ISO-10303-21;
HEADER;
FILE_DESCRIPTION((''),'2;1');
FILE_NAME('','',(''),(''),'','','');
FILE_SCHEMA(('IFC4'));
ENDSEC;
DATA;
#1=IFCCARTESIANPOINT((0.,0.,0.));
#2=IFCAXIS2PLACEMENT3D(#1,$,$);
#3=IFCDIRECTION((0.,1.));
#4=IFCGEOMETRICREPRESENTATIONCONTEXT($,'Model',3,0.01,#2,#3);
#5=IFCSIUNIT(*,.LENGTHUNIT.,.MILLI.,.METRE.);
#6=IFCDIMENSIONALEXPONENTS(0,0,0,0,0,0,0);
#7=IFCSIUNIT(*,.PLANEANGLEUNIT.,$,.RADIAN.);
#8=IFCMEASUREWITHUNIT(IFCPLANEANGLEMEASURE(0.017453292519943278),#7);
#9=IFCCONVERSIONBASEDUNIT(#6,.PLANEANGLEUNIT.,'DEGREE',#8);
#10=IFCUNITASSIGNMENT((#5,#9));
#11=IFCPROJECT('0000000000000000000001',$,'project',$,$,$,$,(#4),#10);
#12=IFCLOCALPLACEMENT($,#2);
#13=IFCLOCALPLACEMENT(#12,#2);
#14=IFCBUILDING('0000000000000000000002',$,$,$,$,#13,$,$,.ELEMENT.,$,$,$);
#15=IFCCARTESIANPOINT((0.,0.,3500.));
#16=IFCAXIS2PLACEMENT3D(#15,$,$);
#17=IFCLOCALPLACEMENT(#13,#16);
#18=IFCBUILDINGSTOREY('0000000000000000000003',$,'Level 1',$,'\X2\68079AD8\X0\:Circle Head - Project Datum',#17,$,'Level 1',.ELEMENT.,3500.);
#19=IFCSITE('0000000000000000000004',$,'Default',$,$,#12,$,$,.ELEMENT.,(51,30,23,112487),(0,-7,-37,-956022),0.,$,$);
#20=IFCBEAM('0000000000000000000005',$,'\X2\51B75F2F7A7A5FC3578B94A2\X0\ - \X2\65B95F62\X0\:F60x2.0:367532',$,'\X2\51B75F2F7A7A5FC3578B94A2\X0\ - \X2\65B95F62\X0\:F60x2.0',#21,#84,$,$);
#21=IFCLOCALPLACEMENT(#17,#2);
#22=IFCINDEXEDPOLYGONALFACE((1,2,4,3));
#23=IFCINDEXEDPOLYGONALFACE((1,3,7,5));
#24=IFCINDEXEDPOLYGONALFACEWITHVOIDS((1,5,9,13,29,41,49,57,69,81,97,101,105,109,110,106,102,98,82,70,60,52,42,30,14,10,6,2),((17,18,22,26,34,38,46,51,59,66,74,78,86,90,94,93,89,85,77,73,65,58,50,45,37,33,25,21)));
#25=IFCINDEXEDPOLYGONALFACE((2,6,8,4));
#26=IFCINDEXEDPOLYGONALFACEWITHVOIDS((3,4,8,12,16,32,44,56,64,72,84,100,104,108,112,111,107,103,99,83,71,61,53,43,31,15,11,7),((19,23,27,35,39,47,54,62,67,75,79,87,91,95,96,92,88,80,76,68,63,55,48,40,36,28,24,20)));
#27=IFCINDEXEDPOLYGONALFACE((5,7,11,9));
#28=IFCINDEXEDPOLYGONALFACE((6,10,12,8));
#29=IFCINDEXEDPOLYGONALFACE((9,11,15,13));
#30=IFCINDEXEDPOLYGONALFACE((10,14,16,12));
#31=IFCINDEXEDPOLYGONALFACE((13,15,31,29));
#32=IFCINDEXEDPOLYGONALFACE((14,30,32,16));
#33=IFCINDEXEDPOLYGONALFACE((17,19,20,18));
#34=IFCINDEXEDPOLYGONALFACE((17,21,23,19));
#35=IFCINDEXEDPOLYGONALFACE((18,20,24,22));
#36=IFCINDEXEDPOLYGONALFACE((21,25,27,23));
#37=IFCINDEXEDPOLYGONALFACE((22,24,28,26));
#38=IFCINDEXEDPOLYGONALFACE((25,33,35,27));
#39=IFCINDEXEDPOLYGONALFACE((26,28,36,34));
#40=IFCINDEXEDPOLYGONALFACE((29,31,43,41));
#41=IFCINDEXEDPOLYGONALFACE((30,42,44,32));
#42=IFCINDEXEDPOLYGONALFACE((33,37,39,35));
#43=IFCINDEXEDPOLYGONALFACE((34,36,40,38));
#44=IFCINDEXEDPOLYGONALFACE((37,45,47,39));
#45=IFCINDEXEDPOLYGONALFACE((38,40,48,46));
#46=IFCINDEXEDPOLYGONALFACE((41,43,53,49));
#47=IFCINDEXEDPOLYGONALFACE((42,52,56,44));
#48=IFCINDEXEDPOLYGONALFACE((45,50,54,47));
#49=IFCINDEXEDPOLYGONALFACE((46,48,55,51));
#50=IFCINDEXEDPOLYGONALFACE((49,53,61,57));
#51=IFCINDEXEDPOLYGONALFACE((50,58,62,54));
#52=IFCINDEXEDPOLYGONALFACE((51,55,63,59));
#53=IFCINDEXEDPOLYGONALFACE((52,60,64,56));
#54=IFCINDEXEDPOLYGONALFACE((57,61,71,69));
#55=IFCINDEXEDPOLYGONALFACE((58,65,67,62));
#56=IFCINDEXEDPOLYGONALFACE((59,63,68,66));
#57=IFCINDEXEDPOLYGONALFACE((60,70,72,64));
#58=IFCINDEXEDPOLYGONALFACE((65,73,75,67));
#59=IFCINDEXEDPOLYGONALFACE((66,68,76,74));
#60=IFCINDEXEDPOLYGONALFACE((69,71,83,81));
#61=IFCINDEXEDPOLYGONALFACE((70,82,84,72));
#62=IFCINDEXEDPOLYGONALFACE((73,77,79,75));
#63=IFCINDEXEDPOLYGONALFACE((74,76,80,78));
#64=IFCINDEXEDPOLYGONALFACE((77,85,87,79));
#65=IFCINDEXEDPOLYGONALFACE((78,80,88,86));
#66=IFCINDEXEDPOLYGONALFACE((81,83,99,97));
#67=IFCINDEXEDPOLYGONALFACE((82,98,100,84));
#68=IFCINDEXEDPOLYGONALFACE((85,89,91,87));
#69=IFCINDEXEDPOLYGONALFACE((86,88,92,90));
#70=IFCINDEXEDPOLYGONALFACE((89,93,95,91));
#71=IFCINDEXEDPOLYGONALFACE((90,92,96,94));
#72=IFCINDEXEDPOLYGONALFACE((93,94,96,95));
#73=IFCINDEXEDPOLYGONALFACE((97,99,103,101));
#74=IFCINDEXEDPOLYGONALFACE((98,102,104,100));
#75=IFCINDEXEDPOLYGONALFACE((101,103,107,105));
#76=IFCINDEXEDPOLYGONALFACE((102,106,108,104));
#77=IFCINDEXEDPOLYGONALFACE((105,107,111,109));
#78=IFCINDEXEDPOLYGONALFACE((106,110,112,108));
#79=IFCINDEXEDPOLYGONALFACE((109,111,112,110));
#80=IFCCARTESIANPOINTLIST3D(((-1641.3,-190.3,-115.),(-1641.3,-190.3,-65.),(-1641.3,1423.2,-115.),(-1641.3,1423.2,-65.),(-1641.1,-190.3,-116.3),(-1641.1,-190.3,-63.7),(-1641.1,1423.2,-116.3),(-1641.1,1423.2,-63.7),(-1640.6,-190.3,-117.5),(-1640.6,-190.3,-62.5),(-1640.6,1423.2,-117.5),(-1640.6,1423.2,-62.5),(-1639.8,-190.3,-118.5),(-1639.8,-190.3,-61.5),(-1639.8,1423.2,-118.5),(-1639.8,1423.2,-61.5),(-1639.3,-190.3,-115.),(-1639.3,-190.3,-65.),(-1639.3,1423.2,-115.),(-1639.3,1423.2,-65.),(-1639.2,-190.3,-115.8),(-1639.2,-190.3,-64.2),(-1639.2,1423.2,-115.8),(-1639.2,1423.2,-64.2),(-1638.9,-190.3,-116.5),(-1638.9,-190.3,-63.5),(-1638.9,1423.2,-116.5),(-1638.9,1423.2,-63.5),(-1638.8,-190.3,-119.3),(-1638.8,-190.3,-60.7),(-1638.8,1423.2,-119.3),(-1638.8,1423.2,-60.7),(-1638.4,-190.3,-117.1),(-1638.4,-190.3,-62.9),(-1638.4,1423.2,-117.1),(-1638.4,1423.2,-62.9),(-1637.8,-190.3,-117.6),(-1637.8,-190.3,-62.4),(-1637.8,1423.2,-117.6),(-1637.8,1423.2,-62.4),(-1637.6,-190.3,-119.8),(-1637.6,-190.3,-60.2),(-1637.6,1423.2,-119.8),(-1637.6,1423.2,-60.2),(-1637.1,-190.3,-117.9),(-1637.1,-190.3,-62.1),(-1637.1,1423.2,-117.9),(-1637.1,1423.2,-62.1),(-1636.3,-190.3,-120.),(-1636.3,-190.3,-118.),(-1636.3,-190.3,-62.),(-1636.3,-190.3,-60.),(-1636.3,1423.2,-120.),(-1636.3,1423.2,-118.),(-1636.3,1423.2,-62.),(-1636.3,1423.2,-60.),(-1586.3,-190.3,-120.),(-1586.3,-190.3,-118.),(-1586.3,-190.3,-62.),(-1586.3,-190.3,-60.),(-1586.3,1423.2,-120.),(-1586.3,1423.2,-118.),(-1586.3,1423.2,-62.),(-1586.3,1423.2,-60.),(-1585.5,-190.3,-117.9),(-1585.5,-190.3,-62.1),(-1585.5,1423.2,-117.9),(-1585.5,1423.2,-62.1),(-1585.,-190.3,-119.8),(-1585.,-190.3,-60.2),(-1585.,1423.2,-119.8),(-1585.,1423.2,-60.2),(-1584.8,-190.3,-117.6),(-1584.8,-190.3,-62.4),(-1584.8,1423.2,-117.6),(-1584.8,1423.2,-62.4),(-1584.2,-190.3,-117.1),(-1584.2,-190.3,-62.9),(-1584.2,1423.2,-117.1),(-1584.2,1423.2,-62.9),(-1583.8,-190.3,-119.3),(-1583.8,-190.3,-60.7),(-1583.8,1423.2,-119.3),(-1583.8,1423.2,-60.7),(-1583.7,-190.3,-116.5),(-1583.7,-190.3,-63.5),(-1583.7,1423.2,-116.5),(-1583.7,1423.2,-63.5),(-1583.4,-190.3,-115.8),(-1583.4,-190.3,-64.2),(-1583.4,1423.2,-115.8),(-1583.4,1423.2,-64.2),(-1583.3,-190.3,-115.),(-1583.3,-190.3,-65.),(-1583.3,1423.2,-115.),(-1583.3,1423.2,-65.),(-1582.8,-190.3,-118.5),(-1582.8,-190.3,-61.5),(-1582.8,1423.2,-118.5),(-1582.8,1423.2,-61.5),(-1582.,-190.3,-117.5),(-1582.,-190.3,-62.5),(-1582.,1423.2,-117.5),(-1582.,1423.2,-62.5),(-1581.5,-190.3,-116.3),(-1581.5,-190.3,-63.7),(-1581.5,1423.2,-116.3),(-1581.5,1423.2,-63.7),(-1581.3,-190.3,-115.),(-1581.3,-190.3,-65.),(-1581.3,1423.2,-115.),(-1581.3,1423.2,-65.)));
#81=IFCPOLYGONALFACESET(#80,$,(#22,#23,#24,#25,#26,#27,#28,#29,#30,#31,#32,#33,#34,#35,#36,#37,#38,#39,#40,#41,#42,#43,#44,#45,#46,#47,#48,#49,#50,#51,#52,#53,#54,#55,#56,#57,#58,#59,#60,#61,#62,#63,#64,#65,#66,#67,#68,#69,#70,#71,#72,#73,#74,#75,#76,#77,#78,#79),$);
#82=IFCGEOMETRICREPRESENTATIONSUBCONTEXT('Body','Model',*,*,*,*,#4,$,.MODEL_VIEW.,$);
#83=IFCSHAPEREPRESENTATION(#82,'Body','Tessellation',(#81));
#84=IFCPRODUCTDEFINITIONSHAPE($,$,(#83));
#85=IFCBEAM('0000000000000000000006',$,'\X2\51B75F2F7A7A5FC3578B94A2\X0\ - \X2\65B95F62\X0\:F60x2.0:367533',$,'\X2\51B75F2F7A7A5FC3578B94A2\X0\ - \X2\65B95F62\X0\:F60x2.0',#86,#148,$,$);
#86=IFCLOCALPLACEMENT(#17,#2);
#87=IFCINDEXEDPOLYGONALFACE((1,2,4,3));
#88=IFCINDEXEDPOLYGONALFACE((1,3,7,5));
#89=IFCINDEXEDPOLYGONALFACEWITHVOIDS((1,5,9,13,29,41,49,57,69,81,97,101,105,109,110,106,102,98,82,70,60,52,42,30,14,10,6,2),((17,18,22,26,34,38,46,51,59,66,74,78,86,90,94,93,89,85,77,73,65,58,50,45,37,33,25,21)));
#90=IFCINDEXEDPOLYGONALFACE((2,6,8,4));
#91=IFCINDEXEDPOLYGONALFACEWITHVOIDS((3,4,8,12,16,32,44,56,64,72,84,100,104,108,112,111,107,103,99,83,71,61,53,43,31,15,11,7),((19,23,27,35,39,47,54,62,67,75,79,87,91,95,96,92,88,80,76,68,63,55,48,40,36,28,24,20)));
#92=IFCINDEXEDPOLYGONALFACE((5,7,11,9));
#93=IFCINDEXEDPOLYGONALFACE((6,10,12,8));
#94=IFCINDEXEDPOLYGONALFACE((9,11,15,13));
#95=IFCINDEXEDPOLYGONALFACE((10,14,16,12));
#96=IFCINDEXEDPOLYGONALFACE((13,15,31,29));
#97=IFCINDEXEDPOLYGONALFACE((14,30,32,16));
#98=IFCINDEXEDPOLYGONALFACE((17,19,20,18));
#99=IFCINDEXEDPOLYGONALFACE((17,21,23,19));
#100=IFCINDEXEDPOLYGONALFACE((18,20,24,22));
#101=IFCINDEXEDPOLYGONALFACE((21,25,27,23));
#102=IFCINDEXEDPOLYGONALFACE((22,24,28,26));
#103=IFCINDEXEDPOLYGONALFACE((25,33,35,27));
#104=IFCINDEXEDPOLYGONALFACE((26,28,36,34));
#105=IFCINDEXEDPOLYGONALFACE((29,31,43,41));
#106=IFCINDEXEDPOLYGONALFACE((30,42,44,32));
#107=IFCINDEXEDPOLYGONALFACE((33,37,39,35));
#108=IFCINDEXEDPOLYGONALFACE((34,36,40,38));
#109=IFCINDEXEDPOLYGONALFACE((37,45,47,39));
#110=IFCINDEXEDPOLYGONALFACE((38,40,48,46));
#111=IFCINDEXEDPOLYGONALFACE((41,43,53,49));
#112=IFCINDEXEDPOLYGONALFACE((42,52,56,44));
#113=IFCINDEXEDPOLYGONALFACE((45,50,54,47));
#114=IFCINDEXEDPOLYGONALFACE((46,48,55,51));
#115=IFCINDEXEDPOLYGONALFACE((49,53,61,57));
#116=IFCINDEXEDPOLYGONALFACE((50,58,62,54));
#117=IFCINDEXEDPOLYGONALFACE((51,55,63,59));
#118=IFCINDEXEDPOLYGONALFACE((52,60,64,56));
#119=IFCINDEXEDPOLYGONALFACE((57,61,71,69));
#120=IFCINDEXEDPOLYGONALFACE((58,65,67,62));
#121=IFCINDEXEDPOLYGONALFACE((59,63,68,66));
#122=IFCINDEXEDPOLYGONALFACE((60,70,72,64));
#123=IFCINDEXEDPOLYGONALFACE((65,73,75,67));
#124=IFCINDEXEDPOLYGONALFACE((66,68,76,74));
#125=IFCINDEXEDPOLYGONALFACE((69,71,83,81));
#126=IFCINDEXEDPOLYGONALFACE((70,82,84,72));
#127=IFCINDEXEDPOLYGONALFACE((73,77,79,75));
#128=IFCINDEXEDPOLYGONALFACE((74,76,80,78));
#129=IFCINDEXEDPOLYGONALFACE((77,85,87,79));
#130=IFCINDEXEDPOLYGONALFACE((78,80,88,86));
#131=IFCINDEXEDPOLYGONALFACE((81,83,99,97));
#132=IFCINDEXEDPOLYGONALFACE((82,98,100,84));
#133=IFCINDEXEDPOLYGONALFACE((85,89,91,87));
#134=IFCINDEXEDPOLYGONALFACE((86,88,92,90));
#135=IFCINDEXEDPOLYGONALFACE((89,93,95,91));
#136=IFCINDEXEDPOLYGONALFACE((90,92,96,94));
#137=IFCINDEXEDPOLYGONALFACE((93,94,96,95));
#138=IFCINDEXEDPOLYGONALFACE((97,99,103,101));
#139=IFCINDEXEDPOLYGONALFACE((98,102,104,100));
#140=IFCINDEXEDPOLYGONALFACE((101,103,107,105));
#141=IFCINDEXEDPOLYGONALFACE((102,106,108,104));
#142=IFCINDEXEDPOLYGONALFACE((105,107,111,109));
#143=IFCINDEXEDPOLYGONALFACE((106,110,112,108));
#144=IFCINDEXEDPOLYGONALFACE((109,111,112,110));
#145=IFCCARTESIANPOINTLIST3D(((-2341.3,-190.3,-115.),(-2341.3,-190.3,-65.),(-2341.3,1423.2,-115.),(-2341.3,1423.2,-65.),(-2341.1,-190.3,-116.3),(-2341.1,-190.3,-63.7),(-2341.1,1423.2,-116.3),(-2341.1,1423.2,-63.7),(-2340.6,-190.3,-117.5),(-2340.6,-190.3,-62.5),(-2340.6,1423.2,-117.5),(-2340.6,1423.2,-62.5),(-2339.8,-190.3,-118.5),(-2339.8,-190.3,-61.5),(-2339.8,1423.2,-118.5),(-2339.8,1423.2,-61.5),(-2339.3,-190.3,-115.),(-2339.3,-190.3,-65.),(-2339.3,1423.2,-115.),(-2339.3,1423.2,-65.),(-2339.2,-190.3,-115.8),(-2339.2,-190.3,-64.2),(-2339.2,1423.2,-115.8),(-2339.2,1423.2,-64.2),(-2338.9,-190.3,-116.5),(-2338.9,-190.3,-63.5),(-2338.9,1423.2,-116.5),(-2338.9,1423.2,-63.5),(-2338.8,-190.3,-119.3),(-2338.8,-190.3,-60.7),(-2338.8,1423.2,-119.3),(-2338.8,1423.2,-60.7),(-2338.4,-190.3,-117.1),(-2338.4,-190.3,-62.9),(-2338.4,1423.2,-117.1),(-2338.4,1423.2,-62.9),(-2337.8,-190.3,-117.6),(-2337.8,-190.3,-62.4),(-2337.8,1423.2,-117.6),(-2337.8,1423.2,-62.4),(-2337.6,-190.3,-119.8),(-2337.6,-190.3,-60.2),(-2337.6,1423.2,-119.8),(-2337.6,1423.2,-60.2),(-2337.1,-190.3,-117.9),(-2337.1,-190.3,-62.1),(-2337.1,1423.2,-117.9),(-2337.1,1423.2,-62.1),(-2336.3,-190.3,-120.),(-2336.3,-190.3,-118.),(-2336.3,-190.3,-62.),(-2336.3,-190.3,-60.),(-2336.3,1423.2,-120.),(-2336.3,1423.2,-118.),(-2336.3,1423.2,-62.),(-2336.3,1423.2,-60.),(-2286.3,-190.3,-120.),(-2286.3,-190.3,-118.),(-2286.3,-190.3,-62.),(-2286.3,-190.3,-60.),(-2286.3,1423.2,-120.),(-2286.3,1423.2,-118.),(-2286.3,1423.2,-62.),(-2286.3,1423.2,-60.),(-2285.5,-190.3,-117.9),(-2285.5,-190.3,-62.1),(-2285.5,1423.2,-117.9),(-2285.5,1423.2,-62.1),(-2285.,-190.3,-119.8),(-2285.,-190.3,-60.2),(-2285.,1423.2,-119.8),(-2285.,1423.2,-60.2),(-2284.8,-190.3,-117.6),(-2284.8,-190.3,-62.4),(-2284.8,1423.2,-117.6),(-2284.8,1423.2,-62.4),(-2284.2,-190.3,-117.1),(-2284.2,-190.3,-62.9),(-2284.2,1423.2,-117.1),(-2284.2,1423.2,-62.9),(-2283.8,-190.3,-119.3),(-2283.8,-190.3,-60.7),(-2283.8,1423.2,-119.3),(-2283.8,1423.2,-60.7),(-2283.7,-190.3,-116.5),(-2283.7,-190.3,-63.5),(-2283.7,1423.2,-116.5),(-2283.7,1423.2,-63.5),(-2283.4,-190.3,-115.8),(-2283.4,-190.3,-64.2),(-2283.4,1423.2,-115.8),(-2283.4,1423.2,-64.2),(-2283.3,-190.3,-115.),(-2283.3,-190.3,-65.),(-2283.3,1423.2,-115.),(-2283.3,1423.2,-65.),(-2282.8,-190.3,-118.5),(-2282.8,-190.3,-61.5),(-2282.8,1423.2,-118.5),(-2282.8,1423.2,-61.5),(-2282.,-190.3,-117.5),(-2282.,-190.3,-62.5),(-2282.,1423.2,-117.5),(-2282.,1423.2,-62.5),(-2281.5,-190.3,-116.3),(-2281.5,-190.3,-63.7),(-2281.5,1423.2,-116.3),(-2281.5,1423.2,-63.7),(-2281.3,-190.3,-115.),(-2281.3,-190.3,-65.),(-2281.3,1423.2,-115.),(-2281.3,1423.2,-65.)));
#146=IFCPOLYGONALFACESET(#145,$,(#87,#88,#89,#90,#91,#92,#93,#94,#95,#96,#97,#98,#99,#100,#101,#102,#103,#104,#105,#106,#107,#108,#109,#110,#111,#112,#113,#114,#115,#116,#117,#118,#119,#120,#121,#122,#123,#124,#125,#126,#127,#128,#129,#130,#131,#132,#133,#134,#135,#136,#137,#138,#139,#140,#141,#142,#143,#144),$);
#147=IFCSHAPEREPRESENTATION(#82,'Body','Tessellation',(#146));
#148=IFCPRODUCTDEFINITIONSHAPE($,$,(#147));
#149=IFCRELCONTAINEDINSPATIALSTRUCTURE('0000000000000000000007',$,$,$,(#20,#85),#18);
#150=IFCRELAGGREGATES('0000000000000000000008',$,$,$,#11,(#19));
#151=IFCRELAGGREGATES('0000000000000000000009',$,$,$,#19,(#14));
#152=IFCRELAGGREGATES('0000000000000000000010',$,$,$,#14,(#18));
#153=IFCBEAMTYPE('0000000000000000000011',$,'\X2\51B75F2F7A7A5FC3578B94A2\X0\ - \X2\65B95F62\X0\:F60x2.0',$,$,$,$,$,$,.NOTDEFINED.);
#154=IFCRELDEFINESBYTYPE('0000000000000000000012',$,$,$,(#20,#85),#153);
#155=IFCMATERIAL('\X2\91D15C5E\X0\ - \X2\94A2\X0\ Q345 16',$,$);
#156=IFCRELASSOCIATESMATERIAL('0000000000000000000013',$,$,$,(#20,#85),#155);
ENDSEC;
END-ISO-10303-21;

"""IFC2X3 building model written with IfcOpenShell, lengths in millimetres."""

from ifc_helpers import new_model, entity, si_unit, converted_unit, direction, frame, frame_2d, origin, place, context, subcontext, project, spatial, polyline, circle_curve, parameter, trimmed, segment, composite_curve, outline, extrude, material, type_object, element, save


model = new_model("IFC2X3")

# Units and contexts
model_context = context("Model", 3, precision=0.01, world=origin(), true_north=direction((0.0, 1.0)))
body_context = subcontext(model_context, "Body", "Model", "MODEL_VIEW")
ifc_project = project(units=[si_unit("LENGTHUNIT", "METRE", prefix="MILLI"), converted_unit("PLANEANGLEUNIT", "DEGREE", entity("IfcPlaneAngleMeasure", 0.017453292519943278), si_unit("PLANEANGLEUNIT", "RADIAN"), dimensions=[0, 0, 0, 0, 0, 0, 0])], contexts=[model_context])

# Site, building, storey
site_placement = place(None, origin())
site = spatial("IfcSite", under=ifc_project, at=site_placement, Name="Default", CompositionType="ELEMENT", RefLatitude=(51, 30, 23, 112487), RefLongitude=(0, -7, -37, -956022), RefElevation=0.0)
building_placement = place(site_placement, origin())
building = spatial("IfcBuilding", under=site, at=building_placement, CompositionType="ELEMENT")
storey_placement = place(building_placement, frame((0.0, 0.0, 3500.0)))
storey = spatial("IfcBuildingStorey", under=building, at=storey_placement, Name="Level 1", ObjectType="标高:Circle Head - Project Datum", LongName="Level 1", CompositionType="ELEMENT", Elevation=3500.0)

# Beams
ifc_material_1 = material(Name="金属 - 钢 Q345 16")
beam_type_1 = type_object("IfcBeamType", Name="冷弯空心型钢 - 方形:F60x2.0", PredefinedType="NOTDEFINED")
beam_1_placement = place(storey_placement, frame((-1611.3, 1388.1, -60.0), z_axis=(0.0, 0.0, 1.0), x_axis=(0.0, -1.0, 0.0)))
element("IfcBeam", 1, at=beam_1_placement, inside=storey, type_object=beam_type_1, material=ifc_material_1, Name="冷弯空心型钢 - 方形:F60x2.0:367532", ObjectType="冷弯空心型钢 - 方形:F60x2.0", context=body_context, shape_type="SweptSolid", body=[
    extrude(outline(composite_curve([segment(trimmed(circle_curve(frame_2d((-25.0, 25.0), x_axis=(1.0, 0.0)), 5.0), [parameter(90.0)], [parameter(180.0)], True, "PARAMETER"), True, "CONTINUOUS"), segment(polyline([(-30.0, 25.0), (-30.0, -25.0)]), True, "CONTINUOUS"), segment(trimmed(circle_curve(frame_2d((-25.0, -25.0), x_axis=(1.0, 0.0)), 5.0), [parameter(180.0)], [parameter(270.0)], True, "PARAMETER"), True, "CONTINUOUS"), segment(polyline([(-25.0, -30.0), (25.0, -30.0)]), True, "CONTINUOUS"), segment(trimmed(circle_curve(frame_2d((25.0, -25.0), x_axis=(1.0, 0.0)), 5.0), [parameter(270.0)], [parameter(0.0)], True, "PARAMETER"), True, "CONTINUOUS"), segment(polyline([(30.0, -25.0), (30.0, 25.0)]), True, "CONTINUOUS"), segment(trimmed(circle_curve(frame_2d((25.0, 25.0), x_axis=(1.0, 0.0)), 5.0), [parameter(0.0)], [parameter(90.0)], True, "PARAMETER"), True, "CONTINUOUS"), segment(polyline([(25.0, 30.0), (-25.0, 30.0)]), True, "CONTINUOUS")], self_intersect=False), holes=[composite_curve([segment(polyline([(-25.0, 28.0), (25.0, 28.0)]), True, "CONTINUOUS"), segment(trimmed(circle_curve(frame_2d((25.0, 25.0), x_axis=(1.0, 0.0)), 3.0), [parameter(0.0)], [parameter(90.0)], True, "PARAMETER"), False, "CONTINUOUS"), segment(polyline([(28.0, 25.0), (28.0, -25.0)]), True, "CONTINUOUS"), segment(trimmed(circle_curve(frame_2d((25.0, -25.0), x_axis=(1.0, 0.0)), 3.0), [parameter(270.0)], [parameter(360.0)], True, "PARAMETER"), False, "CONTINUOUS"), segment(polyline([(25.0, -28.0), (-25.0, -28.0)]), True, "CONTINUOUS"), segment(trimmed(circle_curve(frame_2d((-25.0, -25.0), x_axis=(1.0, 0.0)), 3.0), [parameter(180.0)], [parameter(270.0)], True, "PARAMETER"), False, "CONTINUOUS"), segment(polyline([(-28.0, -25.0), (-28.0, 25.0)]), True, "CONTINUOUS"), segment(trimmed(circle_curve(frame_2d((-25.0, 25.0), x_axis=(1.0, 0.0)), 3.0), [parameter(90.0)], [parameter(180.0)], True, "PARAMETER"), False, "CONTINUOUS")], self_intersect=False)]), frame((-35.1, 0.0, -30.0), z_axis=(1.0, 0.0, 0.0), x_axis=(0.0, 1.0, 0.0)), (0.0, 0.0, 1.0), 1613.5),
])
beam_2_placement = place(storey_placement, frame((-2311.3, 1388.1, -60.0), z_axis=(0.0, 0.0, 1.0), x_axis=(0.0, -1.0, 0.0)))
element("IfcBeam", 2, at=beam_2_placement, inside=storey, type_object=beam_type_1, material=ifc_material_1, Name="冷弯空心型钢 - 方形:F60x2.0:367533", ObjectType="冷弯空心型钢 - 方形:F60x2.0", context=body_context, shape_type="SweptSolid", body=[
    extrude(outline(composite_curve([segment(trimmed(circle_curve(frame_2d((-25.0, 25.0), x_axis=(1.0, 0.0)), 5.0), [parameter(90.0)], [parameter(180.0)], True, "PARAMETER"), True, "CONTINUOUS"), segment(polyline([(-30.0, 25.0), (-30.0, -25.0)]), True, "CONTINUOUS"), segment(trimmed(circle_curve(frame_2d((-25.0, -25.0), x_axis=(1.0, 0.0)), 5.0), [parameter(180.0)], [parameter(270.0)], True, "PARAMETER"), True, "CONTINUOUS"), segment(polyline([(-25.0, -30.0), (25.0, -30.0)]), True, "CONTINUOUS"), segment(trimmed(circle_curve(frame_2d((25.0, -25.0), x_axis=(1.0, 0.0)), 5.0), [parameter(270.0)], [parameter(0.0)], True, "PARAMETER"), True, "CONTINUOUS"), segment(polyline([(30.0, -25.0), (30.0, 25.0)]), True, "CONTINUOUS"), segment(trimmed(circle_curve(frame_2d((25.0, 25.0), x_axis=(1.0, 0.0)), 5.0), [parameter(0.0)], [parameter(90.0)], True, "PARAMETER"), True, "CONTINUOUS"), segment(polyline([(25.0, 30.0), (-25.0, 30.0)]), True, "CONTINUOUS")], self_intersect=False), holes=[composite_curve([segment(polyline([(-25.0, 28.0), (25.0, 28.0)]), True, "CONTINUOUS"), segment(trimmed(circle_curve(frame_2d((25.0, 25.0), x_axis=(1.0, 0.0)), 3.0), [parameter(0.0)], [parameter(90.0)], True, "PARAMETER"), False, "CONTINUOUS"), segment(polyline([(28.0, 25.0), (28.0, -25.0)]), True, "CONTINUOUS"), segment(trimmed(circle_curve(frame_2d((25.0, -25.0), x_axis=(1.0, 0.0)), 3.0), [parameter(270.0)], [parameter(360.0)], True, "PARAMETER"), False, "CONTINUOUS"), segment(polyline([(25.0, -28.0), (-25.0, -28.0)]), True, "CONTINUOUS"), segment(trimmed(circle_curve(frame_2d((-25.0, -25.0), x_axis=(1.0, 0.0)), 3.0), [parameter(180.0)], [parameter(270.0)], True, "PARAMETER"), False, "CONTINUOUS"), segment(polyline([(-28.0, -25.0), (-28.0, 25.0)]), True, "CONTINUOUS"), segment(trimmed(circle_curve(frame_2d((-25.0, 25.0), x_axis=(1.0, 0.0)), 3.0), [parameter(90.0)], [parameter(180.0)], True, "PARAMETER"), False, "CONTINUOUS")], self_intersect=False)]), frame((-35.1, 0.0, -30.0), z_axis=(1.0, 0.0, 0.0), x_axis=(0.0, 1.0, 0.0)), (0.0, 0.0, 1.0), 1613.5),
])

save(model, "model.ifc")
